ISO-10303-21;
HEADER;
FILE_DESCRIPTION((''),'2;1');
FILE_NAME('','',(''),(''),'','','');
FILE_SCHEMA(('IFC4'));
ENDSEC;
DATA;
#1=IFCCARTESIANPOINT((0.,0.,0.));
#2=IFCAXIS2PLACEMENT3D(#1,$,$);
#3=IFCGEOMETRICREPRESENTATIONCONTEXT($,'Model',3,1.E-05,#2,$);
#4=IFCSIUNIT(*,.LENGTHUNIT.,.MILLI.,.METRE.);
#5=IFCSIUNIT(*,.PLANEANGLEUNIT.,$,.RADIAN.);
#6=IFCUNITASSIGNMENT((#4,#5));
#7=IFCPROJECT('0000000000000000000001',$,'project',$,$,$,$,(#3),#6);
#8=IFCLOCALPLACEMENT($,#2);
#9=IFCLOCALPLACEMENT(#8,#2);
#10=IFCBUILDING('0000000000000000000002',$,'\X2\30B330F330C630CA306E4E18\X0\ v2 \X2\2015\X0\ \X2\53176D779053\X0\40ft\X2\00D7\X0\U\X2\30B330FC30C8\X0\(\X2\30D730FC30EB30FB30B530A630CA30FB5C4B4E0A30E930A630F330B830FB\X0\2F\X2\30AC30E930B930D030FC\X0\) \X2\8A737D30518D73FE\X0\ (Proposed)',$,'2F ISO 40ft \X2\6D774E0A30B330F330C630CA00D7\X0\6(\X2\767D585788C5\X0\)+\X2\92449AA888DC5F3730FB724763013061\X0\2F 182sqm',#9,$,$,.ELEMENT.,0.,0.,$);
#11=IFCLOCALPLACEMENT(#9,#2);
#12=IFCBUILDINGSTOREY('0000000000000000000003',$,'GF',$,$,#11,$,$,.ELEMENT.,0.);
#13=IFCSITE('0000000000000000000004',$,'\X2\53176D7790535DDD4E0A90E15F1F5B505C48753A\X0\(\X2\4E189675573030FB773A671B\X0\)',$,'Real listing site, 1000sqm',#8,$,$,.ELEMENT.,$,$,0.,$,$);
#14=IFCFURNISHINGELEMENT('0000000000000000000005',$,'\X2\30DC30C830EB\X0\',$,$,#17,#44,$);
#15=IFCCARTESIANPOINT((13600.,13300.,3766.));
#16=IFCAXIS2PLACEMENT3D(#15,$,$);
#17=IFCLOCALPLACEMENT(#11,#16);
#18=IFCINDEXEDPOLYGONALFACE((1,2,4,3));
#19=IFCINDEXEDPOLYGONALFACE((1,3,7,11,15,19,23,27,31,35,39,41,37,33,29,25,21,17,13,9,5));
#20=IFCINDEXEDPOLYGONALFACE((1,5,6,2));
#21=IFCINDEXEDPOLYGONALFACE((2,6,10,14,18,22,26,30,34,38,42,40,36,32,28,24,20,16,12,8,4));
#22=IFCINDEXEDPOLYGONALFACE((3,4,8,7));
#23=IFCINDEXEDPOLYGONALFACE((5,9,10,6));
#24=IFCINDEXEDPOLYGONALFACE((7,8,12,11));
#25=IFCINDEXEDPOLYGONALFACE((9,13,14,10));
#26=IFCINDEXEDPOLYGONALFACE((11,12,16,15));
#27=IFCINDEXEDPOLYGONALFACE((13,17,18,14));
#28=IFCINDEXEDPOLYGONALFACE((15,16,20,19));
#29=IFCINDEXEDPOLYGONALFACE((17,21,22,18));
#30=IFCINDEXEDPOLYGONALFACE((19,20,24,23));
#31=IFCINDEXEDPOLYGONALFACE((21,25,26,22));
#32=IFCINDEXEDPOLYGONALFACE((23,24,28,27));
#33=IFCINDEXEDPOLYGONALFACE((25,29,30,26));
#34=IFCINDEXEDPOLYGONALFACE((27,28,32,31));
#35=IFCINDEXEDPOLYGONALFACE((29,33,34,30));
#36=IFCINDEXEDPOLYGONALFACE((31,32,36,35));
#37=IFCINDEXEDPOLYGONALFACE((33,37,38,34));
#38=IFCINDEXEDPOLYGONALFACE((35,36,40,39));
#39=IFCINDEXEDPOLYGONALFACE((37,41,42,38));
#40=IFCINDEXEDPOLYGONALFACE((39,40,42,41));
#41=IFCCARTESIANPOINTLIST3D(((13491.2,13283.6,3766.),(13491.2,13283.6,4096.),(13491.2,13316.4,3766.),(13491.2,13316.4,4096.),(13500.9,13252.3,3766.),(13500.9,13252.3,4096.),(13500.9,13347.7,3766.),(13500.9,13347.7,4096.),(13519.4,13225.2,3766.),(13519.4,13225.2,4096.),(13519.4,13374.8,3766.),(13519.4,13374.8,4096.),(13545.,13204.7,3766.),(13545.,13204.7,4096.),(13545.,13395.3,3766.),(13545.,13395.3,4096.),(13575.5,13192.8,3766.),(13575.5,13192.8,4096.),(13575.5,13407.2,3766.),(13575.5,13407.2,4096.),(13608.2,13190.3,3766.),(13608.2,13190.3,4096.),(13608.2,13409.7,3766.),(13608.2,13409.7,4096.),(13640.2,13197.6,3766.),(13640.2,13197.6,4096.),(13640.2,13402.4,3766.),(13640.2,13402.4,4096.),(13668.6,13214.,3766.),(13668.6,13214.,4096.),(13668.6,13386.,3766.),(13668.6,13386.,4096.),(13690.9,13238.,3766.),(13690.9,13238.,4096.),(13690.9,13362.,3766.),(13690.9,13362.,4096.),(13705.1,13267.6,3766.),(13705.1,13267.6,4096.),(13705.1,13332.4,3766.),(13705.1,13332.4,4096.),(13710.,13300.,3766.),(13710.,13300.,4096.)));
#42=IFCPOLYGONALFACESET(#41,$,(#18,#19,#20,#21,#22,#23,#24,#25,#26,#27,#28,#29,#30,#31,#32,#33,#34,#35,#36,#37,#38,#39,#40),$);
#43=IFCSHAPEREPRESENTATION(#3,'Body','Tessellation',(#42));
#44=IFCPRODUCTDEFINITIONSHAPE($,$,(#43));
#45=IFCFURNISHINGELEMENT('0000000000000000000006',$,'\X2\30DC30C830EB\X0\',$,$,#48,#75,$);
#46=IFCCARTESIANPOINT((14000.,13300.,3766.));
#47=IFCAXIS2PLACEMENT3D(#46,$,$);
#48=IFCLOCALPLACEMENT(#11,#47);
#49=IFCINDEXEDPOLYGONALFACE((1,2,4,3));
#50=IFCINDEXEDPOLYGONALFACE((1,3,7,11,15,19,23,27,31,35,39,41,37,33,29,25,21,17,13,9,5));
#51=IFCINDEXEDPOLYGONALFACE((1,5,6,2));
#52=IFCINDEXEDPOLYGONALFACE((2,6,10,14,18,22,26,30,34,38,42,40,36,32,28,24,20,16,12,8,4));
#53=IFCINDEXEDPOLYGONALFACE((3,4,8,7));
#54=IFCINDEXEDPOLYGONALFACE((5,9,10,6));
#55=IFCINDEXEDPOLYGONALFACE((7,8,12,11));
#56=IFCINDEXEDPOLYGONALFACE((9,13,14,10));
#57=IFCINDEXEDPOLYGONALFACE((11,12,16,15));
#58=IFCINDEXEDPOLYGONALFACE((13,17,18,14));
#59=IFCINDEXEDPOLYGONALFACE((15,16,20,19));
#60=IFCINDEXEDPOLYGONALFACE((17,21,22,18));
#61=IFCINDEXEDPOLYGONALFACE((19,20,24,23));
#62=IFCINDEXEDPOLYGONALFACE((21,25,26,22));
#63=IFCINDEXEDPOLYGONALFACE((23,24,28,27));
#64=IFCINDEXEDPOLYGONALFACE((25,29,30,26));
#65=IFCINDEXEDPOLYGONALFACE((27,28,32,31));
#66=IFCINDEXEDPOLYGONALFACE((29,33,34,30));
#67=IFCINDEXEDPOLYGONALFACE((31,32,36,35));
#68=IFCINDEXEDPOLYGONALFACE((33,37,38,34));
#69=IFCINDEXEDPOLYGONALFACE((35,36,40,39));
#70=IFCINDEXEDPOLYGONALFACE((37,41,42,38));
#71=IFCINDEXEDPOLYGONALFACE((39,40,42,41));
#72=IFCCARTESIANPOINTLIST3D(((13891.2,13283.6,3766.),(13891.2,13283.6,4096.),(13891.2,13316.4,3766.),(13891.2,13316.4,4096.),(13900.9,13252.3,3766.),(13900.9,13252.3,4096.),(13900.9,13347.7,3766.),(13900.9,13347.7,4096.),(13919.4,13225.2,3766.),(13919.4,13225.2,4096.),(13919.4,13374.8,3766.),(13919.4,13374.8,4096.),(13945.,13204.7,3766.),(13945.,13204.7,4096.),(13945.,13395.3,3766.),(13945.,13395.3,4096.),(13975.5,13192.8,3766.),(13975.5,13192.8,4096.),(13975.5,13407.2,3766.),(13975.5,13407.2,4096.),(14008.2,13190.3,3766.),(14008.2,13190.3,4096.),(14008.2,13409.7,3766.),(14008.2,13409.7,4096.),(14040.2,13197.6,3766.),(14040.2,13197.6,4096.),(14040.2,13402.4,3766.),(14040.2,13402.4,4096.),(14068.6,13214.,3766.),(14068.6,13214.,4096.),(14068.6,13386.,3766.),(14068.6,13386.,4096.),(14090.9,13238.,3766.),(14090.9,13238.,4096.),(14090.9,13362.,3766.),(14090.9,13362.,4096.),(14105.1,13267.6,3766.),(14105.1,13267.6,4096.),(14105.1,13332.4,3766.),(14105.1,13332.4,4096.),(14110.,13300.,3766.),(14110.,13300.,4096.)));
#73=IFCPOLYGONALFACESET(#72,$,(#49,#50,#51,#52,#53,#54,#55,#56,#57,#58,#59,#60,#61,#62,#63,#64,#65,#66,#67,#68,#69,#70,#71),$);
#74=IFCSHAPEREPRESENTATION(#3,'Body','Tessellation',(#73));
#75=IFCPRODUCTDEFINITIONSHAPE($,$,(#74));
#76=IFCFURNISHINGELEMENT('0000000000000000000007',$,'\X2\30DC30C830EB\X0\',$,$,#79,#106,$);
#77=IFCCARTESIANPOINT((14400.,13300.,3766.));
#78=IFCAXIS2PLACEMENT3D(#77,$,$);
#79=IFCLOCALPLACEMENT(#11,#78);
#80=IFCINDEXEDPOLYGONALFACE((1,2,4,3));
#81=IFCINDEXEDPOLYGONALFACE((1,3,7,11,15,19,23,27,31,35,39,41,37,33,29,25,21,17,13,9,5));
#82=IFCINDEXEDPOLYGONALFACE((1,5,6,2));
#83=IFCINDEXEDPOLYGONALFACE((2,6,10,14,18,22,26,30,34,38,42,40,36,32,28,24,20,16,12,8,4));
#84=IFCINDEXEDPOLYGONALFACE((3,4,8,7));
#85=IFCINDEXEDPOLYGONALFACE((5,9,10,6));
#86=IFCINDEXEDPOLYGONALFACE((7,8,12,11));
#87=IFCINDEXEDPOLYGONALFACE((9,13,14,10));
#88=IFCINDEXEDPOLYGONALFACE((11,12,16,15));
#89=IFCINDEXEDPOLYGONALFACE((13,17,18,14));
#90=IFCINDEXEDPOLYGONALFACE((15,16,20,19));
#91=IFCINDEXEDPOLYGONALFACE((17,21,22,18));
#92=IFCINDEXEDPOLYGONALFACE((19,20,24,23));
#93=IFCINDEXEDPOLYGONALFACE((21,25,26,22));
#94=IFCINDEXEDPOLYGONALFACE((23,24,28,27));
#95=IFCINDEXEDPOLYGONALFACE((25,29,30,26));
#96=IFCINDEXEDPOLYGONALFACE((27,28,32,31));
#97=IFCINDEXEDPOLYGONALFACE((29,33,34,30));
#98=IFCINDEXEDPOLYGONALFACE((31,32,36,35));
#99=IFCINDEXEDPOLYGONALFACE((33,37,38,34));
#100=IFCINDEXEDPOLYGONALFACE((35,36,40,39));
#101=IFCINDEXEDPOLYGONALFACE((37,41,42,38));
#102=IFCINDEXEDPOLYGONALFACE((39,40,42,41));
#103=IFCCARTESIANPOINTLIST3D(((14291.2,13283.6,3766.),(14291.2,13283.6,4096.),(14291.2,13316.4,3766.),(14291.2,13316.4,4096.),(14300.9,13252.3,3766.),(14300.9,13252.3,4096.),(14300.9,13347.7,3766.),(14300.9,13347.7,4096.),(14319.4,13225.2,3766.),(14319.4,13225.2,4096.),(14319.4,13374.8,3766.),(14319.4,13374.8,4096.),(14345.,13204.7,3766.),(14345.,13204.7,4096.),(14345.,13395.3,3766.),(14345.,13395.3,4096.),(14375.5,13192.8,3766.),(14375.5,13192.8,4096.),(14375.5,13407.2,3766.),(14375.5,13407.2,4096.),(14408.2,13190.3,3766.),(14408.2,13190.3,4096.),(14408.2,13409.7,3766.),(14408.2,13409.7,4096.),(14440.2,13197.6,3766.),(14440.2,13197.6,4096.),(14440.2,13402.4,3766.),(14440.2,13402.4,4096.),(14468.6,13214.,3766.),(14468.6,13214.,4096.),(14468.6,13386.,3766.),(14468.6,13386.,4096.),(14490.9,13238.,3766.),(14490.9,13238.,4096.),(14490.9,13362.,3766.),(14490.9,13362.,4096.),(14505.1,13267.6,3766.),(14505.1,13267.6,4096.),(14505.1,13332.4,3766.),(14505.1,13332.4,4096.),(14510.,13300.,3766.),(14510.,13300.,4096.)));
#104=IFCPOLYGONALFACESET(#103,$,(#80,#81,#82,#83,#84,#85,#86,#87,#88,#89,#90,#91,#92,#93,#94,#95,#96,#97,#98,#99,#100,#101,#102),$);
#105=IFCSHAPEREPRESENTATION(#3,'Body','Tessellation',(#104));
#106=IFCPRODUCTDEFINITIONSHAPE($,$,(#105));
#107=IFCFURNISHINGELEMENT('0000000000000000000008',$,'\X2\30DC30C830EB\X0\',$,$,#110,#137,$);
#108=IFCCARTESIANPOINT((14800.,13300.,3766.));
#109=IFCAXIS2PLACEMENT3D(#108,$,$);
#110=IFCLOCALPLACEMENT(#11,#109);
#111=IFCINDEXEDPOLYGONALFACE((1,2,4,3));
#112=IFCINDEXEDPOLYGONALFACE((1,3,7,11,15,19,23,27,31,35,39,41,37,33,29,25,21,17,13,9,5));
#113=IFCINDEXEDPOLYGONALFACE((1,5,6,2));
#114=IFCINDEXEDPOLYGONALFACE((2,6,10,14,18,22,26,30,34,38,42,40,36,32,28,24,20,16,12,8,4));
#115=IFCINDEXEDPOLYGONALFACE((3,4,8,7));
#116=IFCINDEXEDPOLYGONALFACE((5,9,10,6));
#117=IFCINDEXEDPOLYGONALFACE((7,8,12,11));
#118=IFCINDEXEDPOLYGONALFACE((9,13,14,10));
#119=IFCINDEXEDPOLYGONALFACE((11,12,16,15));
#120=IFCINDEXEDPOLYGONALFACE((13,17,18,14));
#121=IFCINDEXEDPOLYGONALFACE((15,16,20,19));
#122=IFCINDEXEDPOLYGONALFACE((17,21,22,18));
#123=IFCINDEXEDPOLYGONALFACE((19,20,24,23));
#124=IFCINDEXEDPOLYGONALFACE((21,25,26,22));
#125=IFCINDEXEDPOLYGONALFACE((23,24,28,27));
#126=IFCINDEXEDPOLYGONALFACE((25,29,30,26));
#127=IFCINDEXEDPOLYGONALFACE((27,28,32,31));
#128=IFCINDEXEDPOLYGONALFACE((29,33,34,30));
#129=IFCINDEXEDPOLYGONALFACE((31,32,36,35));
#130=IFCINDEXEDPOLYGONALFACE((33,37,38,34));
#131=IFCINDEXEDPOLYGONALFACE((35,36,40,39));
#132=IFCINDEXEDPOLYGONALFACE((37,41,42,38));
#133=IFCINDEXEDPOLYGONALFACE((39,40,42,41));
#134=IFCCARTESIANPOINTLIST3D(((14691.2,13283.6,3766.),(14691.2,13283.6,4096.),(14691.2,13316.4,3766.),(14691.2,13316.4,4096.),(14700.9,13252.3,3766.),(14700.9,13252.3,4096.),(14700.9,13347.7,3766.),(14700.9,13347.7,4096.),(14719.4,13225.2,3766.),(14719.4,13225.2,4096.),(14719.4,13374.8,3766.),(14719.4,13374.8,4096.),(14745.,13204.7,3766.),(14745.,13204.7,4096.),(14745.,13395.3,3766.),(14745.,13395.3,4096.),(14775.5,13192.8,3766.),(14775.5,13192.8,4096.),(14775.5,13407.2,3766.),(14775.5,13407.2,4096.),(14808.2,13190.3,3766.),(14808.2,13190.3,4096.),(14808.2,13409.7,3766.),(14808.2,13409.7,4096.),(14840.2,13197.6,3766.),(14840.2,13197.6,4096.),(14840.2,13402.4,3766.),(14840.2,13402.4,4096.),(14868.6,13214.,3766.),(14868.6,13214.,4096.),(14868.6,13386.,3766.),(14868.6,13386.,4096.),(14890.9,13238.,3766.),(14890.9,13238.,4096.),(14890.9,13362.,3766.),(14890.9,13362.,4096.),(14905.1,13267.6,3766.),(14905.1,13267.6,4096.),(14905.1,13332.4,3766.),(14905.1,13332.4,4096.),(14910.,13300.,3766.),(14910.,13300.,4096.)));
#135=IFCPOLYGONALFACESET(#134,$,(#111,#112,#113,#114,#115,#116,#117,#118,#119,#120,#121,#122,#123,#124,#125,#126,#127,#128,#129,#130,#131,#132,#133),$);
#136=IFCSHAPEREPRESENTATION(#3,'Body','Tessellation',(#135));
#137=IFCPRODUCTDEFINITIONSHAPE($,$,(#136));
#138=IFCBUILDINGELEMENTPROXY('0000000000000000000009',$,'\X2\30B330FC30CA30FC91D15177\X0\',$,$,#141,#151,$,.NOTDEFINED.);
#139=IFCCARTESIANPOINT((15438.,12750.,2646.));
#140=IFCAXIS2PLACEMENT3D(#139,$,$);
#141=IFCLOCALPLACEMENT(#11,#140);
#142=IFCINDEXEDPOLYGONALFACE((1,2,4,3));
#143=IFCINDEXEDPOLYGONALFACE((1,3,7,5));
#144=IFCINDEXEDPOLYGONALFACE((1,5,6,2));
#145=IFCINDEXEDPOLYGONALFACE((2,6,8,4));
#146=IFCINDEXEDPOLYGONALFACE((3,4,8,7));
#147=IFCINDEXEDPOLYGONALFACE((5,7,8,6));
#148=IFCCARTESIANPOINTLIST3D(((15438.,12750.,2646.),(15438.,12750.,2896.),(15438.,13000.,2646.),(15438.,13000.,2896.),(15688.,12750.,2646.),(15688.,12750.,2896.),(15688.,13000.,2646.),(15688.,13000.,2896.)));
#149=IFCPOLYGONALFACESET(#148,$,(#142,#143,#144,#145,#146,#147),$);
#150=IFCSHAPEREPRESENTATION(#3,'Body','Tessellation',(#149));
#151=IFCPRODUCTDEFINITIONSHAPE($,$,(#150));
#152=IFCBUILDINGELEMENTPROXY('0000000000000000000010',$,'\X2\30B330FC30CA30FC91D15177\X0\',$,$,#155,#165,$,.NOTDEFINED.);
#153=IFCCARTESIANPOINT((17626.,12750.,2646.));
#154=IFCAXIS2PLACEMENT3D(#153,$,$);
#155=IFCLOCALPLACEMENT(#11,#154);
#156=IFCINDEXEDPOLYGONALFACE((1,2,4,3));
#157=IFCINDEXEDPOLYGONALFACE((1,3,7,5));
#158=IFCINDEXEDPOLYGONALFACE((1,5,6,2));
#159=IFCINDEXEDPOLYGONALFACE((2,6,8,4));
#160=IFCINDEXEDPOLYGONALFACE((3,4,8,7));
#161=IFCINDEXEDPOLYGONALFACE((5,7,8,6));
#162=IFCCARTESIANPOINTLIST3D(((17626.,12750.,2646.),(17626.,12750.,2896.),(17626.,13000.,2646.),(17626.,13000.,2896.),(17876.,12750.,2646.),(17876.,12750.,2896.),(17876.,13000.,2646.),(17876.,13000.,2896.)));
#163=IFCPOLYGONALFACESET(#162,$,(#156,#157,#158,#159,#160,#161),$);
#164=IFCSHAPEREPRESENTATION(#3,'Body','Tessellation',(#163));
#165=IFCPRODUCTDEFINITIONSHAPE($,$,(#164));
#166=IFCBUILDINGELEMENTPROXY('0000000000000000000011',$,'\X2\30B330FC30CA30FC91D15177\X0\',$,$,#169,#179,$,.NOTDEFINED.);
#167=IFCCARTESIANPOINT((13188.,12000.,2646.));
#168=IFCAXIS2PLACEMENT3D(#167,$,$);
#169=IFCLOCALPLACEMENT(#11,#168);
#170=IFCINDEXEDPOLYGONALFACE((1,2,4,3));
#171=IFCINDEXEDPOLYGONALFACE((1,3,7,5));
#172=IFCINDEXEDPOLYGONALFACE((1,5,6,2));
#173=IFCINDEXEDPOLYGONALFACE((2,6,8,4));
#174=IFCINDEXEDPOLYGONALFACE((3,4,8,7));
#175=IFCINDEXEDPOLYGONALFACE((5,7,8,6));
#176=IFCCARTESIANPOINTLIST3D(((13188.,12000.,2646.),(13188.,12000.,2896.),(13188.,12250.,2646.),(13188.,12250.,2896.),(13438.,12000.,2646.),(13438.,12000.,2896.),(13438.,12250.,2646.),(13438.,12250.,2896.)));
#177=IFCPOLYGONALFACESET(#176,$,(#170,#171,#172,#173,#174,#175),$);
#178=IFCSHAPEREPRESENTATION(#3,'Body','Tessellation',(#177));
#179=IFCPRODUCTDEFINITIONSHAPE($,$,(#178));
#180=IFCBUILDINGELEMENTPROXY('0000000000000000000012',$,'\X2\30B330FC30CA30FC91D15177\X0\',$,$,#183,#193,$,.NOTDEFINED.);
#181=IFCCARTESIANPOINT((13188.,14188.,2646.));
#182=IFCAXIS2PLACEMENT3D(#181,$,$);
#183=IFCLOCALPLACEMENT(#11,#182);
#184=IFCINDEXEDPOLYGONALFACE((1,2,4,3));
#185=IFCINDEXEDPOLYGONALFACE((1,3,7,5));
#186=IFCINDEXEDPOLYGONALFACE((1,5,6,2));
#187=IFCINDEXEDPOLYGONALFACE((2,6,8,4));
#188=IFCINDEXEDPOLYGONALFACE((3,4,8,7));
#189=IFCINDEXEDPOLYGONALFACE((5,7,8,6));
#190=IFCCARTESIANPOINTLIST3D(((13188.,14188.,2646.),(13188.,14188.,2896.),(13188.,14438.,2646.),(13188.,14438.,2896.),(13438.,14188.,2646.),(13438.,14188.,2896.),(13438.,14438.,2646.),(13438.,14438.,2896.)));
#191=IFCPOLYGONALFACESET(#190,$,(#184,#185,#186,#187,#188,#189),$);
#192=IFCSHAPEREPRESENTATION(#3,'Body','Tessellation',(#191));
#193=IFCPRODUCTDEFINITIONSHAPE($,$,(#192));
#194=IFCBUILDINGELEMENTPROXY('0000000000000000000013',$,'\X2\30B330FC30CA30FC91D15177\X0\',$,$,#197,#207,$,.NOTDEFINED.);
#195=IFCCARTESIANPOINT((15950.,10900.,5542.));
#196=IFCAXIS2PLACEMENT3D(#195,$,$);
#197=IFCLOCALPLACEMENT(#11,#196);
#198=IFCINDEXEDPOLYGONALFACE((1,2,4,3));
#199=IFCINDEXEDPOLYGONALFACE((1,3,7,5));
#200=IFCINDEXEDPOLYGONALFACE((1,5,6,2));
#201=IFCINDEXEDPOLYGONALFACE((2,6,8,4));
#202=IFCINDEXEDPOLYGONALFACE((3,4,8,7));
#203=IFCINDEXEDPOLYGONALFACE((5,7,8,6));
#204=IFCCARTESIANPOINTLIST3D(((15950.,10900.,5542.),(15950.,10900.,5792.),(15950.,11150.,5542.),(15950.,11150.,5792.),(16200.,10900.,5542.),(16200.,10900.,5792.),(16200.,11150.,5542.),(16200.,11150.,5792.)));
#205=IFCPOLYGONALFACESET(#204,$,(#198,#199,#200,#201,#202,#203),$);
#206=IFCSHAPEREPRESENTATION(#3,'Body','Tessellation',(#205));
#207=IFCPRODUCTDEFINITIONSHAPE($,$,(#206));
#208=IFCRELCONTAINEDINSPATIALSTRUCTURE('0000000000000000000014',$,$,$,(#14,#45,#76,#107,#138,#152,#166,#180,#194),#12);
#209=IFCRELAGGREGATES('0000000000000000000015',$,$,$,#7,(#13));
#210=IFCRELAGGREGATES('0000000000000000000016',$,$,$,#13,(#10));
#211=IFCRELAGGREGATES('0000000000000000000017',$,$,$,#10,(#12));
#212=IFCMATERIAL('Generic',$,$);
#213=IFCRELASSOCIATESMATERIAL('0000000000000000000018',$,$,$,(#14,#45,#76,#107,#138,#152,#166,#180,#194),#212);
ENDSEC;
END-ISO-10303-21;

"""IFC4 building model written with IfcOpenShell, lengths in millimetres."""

from ifc_helpers import new_model, si_unit, frame, frame_2d, origin, origin_2d, place, context, project, spatial, rectangle, circle, extrude, material, element, save


model = new_model("IFC4")

# Units and contexts
model_context = context("Model", 3, precision=1e-05, world=origin())
ifc_project = project(units=[si_unit("LENGTHUNIT", "METRE", prefix="MILLI"), si_unit("PLANEANGLEUNIT", "RADIAN")], contexts=[model_context])

# Site, building, storey
site_placement = place(None, origin())
site = spatial("IfcSite", under=ifc_project, at=site_placement, Name="北海道川上郡弟子屈町(丘陵地・眺望)", ObjectType="Real listing site, 1000sqm", CompositionType="ELEMENT", RefElevation=0.0)
building_placement = place(site_placement, origin())
building = spatial("IfcBuilding", under=site, at=building_placement, Name="コンテナの丘 v2 ― 北海道40ft×Uコート(プール・サウナ・屋上ラウンジ・2Fガラスバー) 詳細再現 (Proposed)", ObjectType="2F ISO 40ft 海上コンテナ×6(白塗装)+鉄骨補強・片持ち2F 182sqm", CompositionType="ELEMENT", ElevationOfRefHeight=0.0, ElevationOfTerrain=0.0)
storey_placement = place(building_placement, origin())
storey = spatial("IfcBuildingStorey", under=building, at=storey_placement, Name="GF", CompositionType="ELEMENT", Elevation=0.0)

# Shared definitions
ifc_material = material(Name="Generic")

# Furnishing elements
furnishing_1_placement = place(storey_placement, frame((13600.0, 13300.0, 3766.0)))
element("IfcFurnishingElement", 1, at=furnishing_1_placement, inside=storey, material=ifc_material, Name="ボトル", context=model_context, shape_type="SweptSolid", body=[
    extrude(circle(Radius=110.0, at=origin_2d()), frame((13600.0, 13300.0, 3766.0)), (0.0, 0.0, 1.0), 330.0),
])
furnishing_2_placement = place(storey_placement, frame((14000.0, 13300.0, 3766.0)))
element("IfcFurnishingElement", 2, at=furnishing_2_placement, inside=storey, material=ifc_material, Name="ボトル", context=model_context, shape_type="SweptSolid", body=[
    extrude(circle(Radius=110.0, at=origin_2d()), frame((14000.0, 13300.0, 3766.0)), (0.0, 0.0, 1.0), 330.0),
])
furnishing_3_placement = place(storey_placement, frame((14400.0, 13300.0, 3766.0)))
element("IfcFurnishingElement", 3, at=furnishing_3_placement, inside=storey, material=ifc_material, Name="ボトル", context=model_context, shape_type="SweptSolid", body=[
    extrude(circle(Radius=110.0, at=origin_2d()), frame((14400.0, 13300.0, 3766.0)), (0.0, 0.0, 1.0), 330.0),
])
furnishing_4_placement = place(storey_placement, frame((14800.0, 13300.0, 3766.0)))
element("IfcFurnishingElement", 4, at=furnishing_4_placement, inside=storey, material=ifc_material, Name="ボトル", context=model_context, shape_type="SweptSolid", body=[
    extrude(circle(Radius=110.0, at=origin_2d()), frame((14800.0, 13300.0, 3766.0)), (0.0, 0.0, 1.0), 330.0),
])

# Building element proxies
proxy_1_placement = place(storey_placement, frame((15438.0, 12750.0, 2646.0)))
element("IfcBuildingElementProxy", 5, at=proxy_1_placement, inside=storey, material=ifc_material, Name="コーナー金具", PredefinedType="NOTDEFINED", context=model_context, shape_type="SweptSolid", body=[
    extrude(rectangle(XDim=250.0, YDim=250.0, at=frame_2d((125.0, 125.0))), frame((15438.0, 12750.0, 2646.0)), (0.0, 0.0, 1.0), 250.0),
])
proxy_2_placement = place(storey_placement, frame((17626.0, 12750.0, 2646.0)))
element("IfcBuildingElementProxy", 6, at=proxy_2_placement, inside=storey, material=ifc_material, Name="コーナー金具", PredefinedType="NOTDEFINED", context=model_context, shape_type="SweptSolid", body=[
    extrude(rectangle(XDim=250.0, YDim=250.0, at=frame_2d((125.0, 125.0))), frame((17626.0, 12750.0, 2646.0)), (0.0, 0.0, 1.0), 250.0),
])
proxy_3_placement = place(storey_placement, frame((13188.0, 12000.0, 2646.0)))
element("IfcBuildingElementProxy", 7, at=proxy_3_placement, inside=storey, material=ifc_material, Name="コーナー金具", PredefinedType="NOTDEFINED", context=model_context, shape_type="SweptSolid", body=[
    extrude(rectangle(XDim=250.0, YDim=250.0, at=frame_2d((125.0, 125.0))), frame((13188.0, 12000.0, 2646.0)), (0.0, 0.0, 1.0), 250.0),
])
proxy_4_placement = place(storey_placement, frame((13188.0, 14188.0, 2646.0)))
element("IfcBuildingElementProxy", 8, at=proxy_4_placement, inside=storey, material=ifc_material, Name="コーナー金具", PredefinedType="NOTDEFINED", context=model_context, shape_type="SweptSolid", body=[
    extrude(rectangle(XDim=250.0, YDim=250.0, at=frame_2d((125.0, 125.0))), frame((13188.0, 14188.0, 2646.0)), (0.0, 0.0, 1.0), 250.0),
])
proxy_5_placement = place(storey_placement, frame((15950.0, 10900.0, 5542.0)))
element("IfcBuildingElementProxy", 9, at=proxy_5_placement, inside=storey, material=ifc_material, Name="コーナー金具", PredefinedType="NOTDEFINED", context=model_context, shape_type="SweptSolid", body=[
    extrude(rectangle(XDim=250.0, YDim=250.0, at=frame_2d((125.0, 125.0))), frame((15950.0, 10900.0, 5542.0)), (0.0, 0.0, 1.0), 250.0),
])

save(model, "model.ifc")
